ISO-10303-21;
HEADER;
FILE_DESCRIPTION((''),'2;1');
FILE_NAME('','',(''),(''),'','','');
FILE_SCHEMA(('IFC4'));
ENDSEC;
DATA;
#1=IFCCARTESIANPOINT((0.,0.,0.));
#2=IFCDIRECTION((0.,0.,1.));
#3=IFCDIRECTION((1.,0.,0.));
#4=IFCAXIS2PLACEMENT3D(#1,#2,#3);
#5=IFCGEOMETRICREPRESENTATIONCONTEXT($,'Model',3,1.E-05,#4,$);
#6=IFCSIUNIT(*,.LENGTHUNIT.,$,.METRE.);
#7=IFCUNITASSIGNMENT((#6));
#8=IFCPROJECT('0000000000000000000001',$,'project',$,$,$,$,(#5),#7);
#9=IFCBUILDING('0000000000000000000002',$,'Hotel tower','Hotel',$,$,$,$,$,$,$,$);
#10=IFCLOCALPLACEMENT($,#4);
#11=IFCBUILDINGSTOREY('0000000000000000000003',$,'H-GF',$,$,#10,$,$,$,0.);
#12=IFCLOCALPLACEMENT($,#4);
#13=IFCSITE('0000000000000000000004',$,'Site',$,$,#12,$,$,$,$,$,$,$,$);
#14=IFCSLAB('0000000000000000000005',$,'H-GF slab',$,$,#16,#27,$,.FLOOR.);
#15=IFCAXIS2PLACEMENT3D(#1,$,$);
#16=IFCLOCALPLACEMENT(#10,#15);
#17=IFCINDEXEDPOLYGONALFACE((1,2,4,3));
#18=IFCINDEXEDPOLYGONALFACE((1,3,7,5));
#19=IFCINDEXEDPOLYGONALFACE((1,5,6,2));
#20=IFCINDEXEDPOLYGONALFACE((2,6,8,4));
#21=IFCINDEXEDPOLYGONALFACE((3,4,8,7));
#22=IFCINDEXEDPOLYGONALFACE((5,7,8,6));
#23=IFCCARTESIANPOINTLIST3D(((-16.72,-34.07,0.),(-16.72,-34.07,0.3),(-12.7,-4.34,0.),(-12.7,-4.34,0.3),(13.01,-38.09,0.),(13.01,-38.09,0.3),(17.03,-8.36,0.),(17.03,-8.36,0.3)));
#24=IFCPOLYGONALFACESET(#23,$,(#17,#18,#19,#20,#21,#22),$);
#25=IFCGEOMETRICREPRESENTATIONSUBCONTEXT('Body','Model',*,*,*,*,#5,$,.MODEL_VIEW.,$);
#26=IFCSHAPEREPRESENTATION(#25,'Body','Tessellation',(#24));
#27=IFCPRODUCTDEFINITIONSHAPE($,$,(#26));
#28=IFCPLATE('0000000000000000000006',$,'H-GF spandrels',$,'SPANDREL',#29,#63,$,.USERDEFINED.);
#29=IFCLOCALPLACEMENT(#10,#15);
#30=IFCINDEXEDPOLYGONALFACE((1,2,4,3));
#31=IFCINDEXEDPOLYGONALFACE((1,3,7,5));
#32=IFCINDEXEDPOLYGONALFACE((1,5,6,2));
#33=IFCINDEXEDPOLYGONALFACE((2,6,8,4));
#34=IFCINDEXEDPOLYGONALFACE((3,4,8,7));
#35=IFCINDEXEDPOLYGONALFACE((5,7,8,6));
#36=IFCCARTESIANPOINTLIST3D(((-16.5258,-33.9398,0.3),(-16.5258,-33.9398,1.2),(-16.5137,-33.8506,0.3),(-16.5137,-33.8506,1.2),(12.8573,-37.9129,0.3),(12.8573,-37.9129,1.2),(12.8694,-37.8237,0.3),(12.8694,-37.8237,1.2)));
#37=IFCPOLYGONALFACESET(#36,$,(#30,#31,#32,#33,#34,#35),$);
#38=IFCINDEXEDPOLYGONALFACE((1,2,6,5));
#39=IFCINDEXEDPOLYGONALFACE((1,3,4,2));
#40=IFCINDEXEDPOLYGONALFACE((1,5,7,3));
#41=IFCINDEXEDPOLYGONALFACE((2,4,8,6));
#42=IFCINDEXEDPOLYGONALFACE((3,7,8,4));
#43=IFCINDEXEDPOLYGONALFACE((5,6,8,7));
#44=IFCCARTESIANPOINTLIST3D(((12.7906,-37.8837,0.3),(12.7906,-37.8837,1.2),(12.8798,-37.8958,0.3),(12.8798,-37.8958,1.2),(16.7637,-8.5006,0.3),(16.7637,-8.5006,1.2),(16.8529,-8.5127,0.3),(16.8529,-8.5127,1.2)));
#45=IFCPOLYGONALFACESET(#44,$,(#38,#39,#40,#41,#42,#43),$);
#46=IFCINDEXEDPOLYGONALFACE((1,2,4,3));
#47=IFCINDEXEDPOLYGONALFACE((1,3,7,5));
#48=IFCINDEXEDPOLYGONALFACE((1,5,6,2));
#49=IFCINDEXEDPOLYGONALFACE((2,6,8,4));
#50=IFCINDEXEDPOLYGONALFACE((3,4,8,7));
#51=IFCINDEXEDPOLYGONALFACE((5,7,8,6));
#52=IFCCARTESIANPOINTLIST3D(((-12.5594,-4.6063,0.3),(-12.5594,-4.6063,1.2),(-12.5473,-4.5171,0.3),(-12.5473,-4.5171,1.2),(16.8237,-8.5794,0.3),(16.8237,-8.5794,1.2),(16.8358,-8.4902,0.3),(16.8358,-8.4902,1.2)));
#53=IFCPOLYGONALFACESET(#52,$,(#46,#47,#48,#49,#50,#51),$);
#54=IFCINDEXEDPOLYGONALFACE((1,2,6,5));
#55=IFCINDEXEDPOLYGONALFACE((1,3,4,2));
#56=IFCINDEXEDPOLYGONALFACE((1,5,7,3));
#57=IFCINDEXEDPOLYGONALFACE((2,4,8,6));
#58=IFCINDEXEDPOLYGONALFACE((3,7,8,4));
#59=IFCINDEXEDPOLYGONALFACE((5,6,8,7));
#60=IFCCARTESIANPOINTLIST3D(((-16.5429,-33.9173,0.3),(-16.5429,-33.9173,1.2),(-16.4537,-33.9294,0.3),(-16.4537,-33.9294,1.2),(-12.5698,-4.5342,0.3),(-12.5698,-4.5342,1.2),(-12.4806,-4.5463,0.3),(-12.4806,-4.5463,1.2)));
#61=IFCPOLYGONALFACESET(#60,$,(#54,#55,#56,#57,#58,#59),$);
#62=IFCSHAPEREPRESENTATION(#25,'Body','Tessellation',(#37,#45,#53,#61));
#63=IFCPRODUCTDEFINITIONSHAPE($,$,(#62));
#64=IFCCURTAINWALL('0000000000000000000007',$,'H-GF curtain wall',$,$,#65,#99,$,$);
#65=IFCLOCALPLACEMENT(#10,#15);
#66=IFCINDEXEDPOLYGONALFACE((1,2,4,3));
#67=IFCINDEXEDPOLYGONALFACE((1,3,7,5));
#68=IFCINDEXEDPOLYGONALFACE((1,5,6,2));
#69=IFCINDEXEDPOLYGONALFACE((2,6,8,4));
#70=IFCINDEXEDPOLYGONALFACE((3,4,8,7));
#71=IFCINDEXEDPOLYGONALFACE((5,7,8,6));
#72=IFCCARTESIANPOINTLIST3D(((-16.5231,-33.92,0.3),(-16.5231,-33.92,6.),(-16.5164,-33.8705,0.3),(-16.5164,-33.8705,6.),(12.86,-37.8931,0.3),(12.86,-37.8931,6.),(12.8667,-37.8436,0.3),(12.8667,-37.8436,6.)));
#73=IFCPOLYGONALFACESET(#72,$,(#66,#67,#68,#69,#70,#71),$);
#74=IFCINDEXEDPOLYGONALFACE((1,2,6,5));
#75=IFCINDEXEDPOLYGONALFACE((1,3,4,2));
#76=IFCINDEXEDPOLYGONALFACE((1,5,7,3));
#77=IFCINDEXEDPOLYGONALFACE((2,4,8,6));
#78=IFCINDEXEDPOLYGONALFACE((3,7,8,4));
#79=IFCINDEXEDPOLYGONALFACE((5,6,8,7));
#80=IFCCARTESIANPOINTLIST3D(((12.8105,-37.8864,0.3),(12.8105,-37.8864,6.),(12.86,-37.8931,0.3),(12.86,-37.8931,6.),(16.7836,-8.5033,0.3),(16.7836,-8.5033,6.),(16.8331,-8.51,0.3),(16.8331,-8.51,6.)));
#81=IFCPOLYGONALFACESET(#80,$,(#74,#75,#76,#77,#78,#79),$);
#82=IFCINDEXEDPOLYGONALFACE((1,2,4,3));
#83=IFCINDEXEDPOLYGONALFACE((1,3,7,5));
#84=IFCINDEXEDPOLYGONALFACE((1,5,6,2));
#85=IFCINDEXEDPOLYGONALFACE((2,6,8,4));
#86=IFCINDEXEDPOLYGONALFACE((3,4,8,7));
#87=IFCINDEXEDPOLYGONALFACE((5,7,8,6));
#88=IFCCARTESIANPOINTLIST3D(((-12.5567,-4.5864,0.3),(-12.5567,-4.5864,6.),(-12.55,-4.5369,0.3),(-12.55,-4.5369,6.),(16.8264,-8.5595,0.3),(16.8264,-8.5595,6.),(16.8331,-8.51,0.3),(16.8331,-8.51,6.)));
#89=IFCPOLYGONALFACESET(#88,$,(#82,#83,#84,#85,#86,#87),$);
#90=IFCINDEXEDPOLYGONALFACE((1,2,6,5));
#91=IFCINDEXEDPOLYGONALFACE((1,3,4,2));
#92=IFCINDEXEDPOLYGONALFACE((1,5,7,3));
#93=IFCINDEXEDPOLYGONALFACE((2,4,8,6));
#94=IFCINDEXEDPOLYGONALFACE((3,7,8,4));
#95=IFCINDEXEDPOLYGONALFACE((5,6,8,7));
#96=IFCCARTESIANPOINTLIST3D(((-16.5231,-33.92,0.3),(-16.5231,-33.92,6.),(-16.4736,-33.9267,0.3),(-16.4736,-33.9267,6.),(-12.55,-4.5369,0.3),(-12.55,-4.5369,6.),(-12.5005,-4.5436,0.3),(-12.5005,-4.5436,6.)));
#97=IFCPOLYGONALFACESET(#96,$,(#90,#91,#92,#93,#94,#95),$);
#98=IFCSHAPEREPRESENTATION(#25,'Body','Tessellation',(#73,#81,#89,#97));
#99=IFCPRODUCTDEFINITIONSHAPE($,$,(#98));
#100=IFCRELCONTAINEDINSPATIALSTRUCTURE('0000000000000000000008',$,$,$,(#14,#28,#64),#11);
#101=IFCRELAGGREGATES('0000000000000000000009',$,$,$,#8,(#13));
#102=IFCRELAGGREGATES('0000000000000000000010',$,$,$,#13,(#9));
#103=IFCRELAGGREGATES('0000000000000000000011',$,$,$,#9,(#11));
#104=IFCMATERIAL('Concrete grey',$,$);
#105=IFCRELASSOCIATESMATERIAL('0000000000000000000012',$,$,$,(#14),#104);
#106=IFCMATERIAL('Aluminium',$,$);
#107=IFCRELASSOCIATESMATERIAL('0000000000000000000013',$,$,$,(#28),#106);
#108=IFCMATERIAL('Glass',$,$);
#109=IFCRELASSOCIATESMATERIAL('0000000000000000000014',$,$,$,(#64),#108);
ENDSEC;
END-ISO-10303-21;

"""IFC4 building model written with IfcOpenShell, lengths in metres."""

from ifc_helpers import new_model, si_unit, frame, origin_with_axes, place, context, subcontext, project, spatial, polyline, outline, extrude, material, element, save


model = new_model("IFC4")

# Units and contexts
model_context = context("Model", 3, precision=1e-05, world=origin_with_axes())
body_context = subcontext(model_context, "Body", "Model", "MODEL_VIEW")
ifc_project = project(units=[si_unit("LENGTHUNIT", "METRE")], contexts=[model_context])

# Site, building, storey
site_placement = place(None, origin_with_axes())
site = spatial("IfcSite", under=ifc_project, at=site_placement, Name="Site")
building = spatial("IfcBuilding", under=site, Name="Hotel tower", Description="Hotel")
storey_placement = place(None, origin_with_axes())
storey = spatial("IfcBuildingStorey", under=building, at=storey_placement, Name="H-GF", Elevation=0.0)

# Shared definitions
ifc_material_1 = material(Name="Aluminium")

# Slab
ifc_material_2 = material(Name="Concrete grey")
slab_placement = place(storey_placement, origin_with_axes())
element("IfcSlab", 1, at=slab_placement, inside=storey, material=ifc_material_2, Name="H-GF slab", PredefinedType="FLOOR", context=body_context, shape_type="SweptSolid", body=[
    extrude(outline(polyline([(-16.72, -34.07), (13.01, -38.09), (17.03, -8.36), (-12.7, -4.34), (-16.72, -34.07)])), origin_with_axes(), (0.0, 0.0, 1.0), 0.3),
])

# Plate
plate_placement = place(storey_placement, origin_with_axes())
element("IfcPlate", 2, at=plate_placement, inside=storey, material=ifc_material_1, Name="H-GF spandrels", ObjectType="SPANDREL", PredefinedType="USERDEFINED", context=body_context, shape_type="SweptSolid", body=[
    extrude(outline(polyline([(-16.5258, -33.9398), (12.8573, -37.9129), (12.8694, -37.8237), (-16.5137, -33.8506), (-16.5258, -33.9398)])), frame((0.0, 0.0, 0.3), z_axis=(0.0, 0.0, 1.0), x_axis=(1.0, 0.0, 0.0)), (0.0, 0.0, 1.0), 0.9),
    extrude(outline(polyline([(12.8798, -37.8958), (16.8529, -8.5127), (16.7637, -8.5006), (12.7906, -37.8837), (12.8798, -37.8958)])), frame((0.0, 0.0, 0.3), z_axis=(0.0, 0.0, 1.0), x_axis=(1.0, 0.0, 0.0)), (0.0, 0.0, 1.0), 0.9),
    extrude(outline(polyline([(16.8358, -8.4902), (-12.5473, -4.5171), (-12.5594, -4.6063), (16.8237, -8.5794), (16.8358, -8.4902)])), frame((0.0, 0.0, 0.3), z_axis=(0.0, 0.0, 1.0), x_axis=(1.0, 0.0, 0.0)), (0.0, 0.0, 1.0), 0.9),
    extrude(outline(polyline([(-12.5698, -4.5342), (-16.5429, -33.9173), (-16.4537, -33.9294), (-12.4806, -4.5463), (-12.5698, -4.5342)])), frame((0.0, 0.0, 0.3), z_axis=(0.0, 0.0, 1.0), x_axis=(1.0, 0.0, 0.0)), (0.0, 0.0, 1.0), 0.9),
])

# Curtain wall
ifc_material_3 = material(Name="Glass")
curtain_wall_placement = place(storey_placement, origin_with_axes())
element("IfcCurtainWall", 3, at=curtain_wall_placement, inside=storey, material=ifc_material_3, Name="H-GF curtain wall", context=body_context, shape_type="SweptSolid", body=[
    extrude(outline(polyline([(-16.5231, -33.92), (12.86, -37.8931), (12.8667, -37.8436), (-16.5164, -33.8705), (-16.5231, -33.92)])), frame((0.0, 0.0, 0.3), z_axis=(0.0, 0.0, 1.0), x_axis=(1.0, 0.0, 0.0)), (0.0, 0.0, 1.0), 5.7),
    extrude(outline(polyline([(12.86, -37.8931), (16.8331, -8.51), (16.7836, -8.5033), (12.8105, -37.8864), (12.86, -37.8931)])), frame((0.0, 0.0, 0.3), z_axis=(0.0, 0.0, 1.0), x_axis=(1.0, 0.0, 0.0)), (0.0, 0.0, 1.0), 5.7),
    extrude(outline(polyline([(16.8331, -8.51), (-12.55, -4.5369), (-12.5567, -4.5864), (16.8264, -8.5595), (16.8331, -8.51)])), frame((0.0, 0.0, 0.3), z_axis=(0.0, 0.0, 1.0), x_axis=(1.0, 0.0, 0.0)), (0.0, 0.0, 1.0), 5.7),
    extrude(outline(polyline([(-12.55, -4.5369), (-16.5231, -33.92), (-16.4736, -33.9267), (-12.5005, -4.5436), (-12.55, -4.5369)])), frame((0.0, 0.0, 0.3), z_axis=(0.0, 0.0, 1.0), x_axis=(1.0, 0.0, 0.0)), (0.0, 0.0, 1.0), 5.7),
])

save(model, "model.ifc")
